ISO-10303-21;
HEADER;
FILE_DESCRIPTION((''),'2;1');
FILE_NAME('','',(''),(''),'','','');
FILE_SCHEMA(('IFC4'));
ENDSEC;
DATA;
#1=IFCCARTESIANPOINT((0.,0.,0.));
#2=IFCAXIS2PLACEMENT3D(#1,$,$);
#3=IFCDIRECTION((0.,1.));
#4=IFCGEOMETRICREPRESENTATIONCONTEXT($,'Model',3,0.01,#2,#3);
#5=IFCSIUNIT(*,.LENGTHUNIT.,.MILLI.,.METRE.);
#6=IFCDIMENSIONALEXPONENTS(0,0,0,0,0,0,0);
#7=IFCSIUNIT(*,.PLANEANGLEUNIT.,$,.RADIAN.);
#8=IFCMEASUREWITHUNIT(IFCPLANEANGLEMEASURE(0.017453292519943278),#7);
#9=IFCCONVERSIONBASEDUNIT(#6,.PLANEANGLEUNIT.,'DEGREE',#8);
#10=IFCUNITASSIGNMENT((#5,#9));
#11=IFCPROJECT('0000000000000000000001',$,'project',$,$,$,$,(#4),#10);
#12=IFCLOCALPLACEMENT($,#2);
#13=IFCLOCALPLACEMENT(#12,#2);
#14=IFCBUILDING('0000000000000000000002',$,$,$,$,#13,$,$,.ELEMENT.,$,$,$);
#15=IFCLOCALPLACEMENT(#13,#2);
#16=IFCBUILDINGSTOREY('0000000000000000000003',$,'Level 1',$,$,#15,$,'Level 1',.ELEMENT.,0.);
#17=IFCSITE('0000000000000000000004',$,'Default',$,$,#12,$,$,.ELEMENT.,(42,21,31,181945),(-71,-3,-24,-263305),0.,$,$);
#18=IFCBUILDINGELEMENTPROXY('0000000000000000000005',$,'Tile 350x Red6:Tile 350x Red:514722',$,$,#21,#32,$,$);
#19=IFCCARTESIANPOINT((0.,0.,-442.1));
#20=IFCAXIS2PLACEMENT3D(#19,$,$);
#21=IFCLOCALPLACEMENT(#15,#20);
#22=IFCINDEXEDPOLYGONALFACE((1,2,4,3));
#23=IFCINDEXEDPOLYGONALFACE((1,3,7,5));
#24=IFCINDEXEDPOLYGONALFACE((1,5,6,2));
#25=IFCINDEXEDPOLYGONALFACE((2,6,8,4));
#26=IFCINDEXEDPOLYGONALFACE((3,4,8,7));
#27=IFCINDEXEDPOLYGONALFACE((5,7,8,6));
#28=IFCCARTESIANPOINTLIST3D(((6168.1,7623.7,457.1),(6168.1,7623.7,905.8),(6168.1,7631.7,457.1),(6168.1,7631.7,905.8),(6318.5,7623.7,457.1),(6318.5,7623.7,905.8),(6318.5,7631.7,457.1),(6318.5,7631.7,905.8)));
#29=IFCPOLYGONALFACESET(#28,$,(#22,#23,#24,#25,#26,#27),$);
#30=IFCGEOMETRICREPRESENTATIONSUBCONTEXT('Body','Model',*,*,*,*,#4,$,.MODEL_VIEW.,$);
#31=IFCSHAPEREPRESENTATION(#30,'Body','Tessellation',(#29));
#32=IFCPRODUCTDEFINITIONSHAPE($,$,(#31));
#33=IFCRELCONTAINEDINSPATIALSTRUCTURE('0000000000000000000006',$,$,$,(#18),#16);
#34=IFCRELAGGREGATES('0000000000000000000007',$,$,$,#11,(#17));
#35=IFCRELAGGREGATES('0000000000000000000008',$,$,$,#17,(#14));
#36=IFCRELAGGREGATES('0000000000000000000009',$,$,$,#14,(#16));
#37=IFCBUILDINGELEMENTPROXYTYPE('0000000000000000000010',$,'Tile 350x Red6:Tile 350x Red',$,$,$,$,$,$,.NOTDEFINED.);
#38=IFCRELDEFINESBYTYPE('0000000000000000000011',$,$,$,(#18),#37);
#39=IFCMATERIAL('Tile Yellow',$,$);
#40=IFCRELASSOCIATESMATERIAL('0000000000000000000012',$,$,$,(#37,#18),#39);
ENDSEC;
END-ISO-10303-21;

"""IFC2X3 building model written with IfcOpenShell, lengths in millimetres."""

from ifc_helpers import new_model, entity, si_unit, converted_unit, direction, frame, frame_2d, origin, place, context, subcontext, project, spatial, rectangle, extrude, source, transform, mapped, material, type_object, type_shapes, element, save


model = new_model("IFC2X3")

# Units and contexts
model_context = context("Model", 3, precision=0.01, world=origin(), true_north=direction((0.0, 1.0)))
body_context = subcontext(model_context, "Body", "Model", "MODEL_VIEW")
ifc_project = project(units=[si_unit("LENGTHUNIT", "METRE", prefix="MILLI"), converted_unit("PLANEANGLEUNIT", "DEGREE", entity("IfcPlaneAngleMeasure", 0.017453292519943278), si_unit("PLANEANGLEUNIT", "RADIAN"), dimensions=[0, 0, 0, 0, 0, 0, 0])], contexts=[model_context])

# Site, building, storey
site_placement = place(None, origin())
site = spatial("IfcSite", under=ifc_project, at=site_placement, Name="Default", CompositionType="ELEMENT", RefLatitude=(42, 21, 31, 181945), RefLongitude=(-71, -3, -24, -263305), RefElevation=0.0)
building_placement = place(site_placement, origin())
building = spatial("IfcBuilding", under=site, at=building_placement, CompositionType="ELEMENT")
storey_placement = place(building_placement, origin())
storey = spatial("IfcBuildingStorey", under=building, at=storey_placement, Name="Level 1", LongName="Level 1", CompositionType="ELEMENT", Elevation=0.0)

# Building element proxy
ifc_material_1 = material(Name="Tile Yellow")
building_element_proxy_type_1 = type_object("IfcBuildingElementProxyType", Name="Tile 350x Red6:Tile 350x Red", PredefinedType="NOTDEFINED", material=ifc_material_1)
shared_shape_1 = source(origin(), body_context, "Body", "SweptSolid", [
    extrude(rectangle(XDim=8.0, YDim=150.5, at=frame_2d((0.0, 0.0), x_axis=(1.0, 0.0))), frame((6243.3, 7627.7, 457.1), z_axis=(0.0, 0.0, 1.0), x_axis=(0.0, -1.0, 0.0)), (0.0, 0.0, 1.0), 448.8),
])
type_shapes(building_element_proxy_type_1, [shared_shape_1])
proxy_1_placement = place(storey_placement, frame((0.0, 0.0, -442.1)))
element("IfcBuildingElementProxy", 1, at=proxy_1_placement, inside=storey, type_object=building_element_proxy_type_1, material=ifc_material_1, Name="Tile 350x Red6:Tile 350x Red:514722", context=body_context, shape_type="MappedRepresentation", body=[
    mapped(shared_shape_1, transform((0.0, 0.0, 0.0), scale=1.0)),
])

save(model, "model.ifc")
